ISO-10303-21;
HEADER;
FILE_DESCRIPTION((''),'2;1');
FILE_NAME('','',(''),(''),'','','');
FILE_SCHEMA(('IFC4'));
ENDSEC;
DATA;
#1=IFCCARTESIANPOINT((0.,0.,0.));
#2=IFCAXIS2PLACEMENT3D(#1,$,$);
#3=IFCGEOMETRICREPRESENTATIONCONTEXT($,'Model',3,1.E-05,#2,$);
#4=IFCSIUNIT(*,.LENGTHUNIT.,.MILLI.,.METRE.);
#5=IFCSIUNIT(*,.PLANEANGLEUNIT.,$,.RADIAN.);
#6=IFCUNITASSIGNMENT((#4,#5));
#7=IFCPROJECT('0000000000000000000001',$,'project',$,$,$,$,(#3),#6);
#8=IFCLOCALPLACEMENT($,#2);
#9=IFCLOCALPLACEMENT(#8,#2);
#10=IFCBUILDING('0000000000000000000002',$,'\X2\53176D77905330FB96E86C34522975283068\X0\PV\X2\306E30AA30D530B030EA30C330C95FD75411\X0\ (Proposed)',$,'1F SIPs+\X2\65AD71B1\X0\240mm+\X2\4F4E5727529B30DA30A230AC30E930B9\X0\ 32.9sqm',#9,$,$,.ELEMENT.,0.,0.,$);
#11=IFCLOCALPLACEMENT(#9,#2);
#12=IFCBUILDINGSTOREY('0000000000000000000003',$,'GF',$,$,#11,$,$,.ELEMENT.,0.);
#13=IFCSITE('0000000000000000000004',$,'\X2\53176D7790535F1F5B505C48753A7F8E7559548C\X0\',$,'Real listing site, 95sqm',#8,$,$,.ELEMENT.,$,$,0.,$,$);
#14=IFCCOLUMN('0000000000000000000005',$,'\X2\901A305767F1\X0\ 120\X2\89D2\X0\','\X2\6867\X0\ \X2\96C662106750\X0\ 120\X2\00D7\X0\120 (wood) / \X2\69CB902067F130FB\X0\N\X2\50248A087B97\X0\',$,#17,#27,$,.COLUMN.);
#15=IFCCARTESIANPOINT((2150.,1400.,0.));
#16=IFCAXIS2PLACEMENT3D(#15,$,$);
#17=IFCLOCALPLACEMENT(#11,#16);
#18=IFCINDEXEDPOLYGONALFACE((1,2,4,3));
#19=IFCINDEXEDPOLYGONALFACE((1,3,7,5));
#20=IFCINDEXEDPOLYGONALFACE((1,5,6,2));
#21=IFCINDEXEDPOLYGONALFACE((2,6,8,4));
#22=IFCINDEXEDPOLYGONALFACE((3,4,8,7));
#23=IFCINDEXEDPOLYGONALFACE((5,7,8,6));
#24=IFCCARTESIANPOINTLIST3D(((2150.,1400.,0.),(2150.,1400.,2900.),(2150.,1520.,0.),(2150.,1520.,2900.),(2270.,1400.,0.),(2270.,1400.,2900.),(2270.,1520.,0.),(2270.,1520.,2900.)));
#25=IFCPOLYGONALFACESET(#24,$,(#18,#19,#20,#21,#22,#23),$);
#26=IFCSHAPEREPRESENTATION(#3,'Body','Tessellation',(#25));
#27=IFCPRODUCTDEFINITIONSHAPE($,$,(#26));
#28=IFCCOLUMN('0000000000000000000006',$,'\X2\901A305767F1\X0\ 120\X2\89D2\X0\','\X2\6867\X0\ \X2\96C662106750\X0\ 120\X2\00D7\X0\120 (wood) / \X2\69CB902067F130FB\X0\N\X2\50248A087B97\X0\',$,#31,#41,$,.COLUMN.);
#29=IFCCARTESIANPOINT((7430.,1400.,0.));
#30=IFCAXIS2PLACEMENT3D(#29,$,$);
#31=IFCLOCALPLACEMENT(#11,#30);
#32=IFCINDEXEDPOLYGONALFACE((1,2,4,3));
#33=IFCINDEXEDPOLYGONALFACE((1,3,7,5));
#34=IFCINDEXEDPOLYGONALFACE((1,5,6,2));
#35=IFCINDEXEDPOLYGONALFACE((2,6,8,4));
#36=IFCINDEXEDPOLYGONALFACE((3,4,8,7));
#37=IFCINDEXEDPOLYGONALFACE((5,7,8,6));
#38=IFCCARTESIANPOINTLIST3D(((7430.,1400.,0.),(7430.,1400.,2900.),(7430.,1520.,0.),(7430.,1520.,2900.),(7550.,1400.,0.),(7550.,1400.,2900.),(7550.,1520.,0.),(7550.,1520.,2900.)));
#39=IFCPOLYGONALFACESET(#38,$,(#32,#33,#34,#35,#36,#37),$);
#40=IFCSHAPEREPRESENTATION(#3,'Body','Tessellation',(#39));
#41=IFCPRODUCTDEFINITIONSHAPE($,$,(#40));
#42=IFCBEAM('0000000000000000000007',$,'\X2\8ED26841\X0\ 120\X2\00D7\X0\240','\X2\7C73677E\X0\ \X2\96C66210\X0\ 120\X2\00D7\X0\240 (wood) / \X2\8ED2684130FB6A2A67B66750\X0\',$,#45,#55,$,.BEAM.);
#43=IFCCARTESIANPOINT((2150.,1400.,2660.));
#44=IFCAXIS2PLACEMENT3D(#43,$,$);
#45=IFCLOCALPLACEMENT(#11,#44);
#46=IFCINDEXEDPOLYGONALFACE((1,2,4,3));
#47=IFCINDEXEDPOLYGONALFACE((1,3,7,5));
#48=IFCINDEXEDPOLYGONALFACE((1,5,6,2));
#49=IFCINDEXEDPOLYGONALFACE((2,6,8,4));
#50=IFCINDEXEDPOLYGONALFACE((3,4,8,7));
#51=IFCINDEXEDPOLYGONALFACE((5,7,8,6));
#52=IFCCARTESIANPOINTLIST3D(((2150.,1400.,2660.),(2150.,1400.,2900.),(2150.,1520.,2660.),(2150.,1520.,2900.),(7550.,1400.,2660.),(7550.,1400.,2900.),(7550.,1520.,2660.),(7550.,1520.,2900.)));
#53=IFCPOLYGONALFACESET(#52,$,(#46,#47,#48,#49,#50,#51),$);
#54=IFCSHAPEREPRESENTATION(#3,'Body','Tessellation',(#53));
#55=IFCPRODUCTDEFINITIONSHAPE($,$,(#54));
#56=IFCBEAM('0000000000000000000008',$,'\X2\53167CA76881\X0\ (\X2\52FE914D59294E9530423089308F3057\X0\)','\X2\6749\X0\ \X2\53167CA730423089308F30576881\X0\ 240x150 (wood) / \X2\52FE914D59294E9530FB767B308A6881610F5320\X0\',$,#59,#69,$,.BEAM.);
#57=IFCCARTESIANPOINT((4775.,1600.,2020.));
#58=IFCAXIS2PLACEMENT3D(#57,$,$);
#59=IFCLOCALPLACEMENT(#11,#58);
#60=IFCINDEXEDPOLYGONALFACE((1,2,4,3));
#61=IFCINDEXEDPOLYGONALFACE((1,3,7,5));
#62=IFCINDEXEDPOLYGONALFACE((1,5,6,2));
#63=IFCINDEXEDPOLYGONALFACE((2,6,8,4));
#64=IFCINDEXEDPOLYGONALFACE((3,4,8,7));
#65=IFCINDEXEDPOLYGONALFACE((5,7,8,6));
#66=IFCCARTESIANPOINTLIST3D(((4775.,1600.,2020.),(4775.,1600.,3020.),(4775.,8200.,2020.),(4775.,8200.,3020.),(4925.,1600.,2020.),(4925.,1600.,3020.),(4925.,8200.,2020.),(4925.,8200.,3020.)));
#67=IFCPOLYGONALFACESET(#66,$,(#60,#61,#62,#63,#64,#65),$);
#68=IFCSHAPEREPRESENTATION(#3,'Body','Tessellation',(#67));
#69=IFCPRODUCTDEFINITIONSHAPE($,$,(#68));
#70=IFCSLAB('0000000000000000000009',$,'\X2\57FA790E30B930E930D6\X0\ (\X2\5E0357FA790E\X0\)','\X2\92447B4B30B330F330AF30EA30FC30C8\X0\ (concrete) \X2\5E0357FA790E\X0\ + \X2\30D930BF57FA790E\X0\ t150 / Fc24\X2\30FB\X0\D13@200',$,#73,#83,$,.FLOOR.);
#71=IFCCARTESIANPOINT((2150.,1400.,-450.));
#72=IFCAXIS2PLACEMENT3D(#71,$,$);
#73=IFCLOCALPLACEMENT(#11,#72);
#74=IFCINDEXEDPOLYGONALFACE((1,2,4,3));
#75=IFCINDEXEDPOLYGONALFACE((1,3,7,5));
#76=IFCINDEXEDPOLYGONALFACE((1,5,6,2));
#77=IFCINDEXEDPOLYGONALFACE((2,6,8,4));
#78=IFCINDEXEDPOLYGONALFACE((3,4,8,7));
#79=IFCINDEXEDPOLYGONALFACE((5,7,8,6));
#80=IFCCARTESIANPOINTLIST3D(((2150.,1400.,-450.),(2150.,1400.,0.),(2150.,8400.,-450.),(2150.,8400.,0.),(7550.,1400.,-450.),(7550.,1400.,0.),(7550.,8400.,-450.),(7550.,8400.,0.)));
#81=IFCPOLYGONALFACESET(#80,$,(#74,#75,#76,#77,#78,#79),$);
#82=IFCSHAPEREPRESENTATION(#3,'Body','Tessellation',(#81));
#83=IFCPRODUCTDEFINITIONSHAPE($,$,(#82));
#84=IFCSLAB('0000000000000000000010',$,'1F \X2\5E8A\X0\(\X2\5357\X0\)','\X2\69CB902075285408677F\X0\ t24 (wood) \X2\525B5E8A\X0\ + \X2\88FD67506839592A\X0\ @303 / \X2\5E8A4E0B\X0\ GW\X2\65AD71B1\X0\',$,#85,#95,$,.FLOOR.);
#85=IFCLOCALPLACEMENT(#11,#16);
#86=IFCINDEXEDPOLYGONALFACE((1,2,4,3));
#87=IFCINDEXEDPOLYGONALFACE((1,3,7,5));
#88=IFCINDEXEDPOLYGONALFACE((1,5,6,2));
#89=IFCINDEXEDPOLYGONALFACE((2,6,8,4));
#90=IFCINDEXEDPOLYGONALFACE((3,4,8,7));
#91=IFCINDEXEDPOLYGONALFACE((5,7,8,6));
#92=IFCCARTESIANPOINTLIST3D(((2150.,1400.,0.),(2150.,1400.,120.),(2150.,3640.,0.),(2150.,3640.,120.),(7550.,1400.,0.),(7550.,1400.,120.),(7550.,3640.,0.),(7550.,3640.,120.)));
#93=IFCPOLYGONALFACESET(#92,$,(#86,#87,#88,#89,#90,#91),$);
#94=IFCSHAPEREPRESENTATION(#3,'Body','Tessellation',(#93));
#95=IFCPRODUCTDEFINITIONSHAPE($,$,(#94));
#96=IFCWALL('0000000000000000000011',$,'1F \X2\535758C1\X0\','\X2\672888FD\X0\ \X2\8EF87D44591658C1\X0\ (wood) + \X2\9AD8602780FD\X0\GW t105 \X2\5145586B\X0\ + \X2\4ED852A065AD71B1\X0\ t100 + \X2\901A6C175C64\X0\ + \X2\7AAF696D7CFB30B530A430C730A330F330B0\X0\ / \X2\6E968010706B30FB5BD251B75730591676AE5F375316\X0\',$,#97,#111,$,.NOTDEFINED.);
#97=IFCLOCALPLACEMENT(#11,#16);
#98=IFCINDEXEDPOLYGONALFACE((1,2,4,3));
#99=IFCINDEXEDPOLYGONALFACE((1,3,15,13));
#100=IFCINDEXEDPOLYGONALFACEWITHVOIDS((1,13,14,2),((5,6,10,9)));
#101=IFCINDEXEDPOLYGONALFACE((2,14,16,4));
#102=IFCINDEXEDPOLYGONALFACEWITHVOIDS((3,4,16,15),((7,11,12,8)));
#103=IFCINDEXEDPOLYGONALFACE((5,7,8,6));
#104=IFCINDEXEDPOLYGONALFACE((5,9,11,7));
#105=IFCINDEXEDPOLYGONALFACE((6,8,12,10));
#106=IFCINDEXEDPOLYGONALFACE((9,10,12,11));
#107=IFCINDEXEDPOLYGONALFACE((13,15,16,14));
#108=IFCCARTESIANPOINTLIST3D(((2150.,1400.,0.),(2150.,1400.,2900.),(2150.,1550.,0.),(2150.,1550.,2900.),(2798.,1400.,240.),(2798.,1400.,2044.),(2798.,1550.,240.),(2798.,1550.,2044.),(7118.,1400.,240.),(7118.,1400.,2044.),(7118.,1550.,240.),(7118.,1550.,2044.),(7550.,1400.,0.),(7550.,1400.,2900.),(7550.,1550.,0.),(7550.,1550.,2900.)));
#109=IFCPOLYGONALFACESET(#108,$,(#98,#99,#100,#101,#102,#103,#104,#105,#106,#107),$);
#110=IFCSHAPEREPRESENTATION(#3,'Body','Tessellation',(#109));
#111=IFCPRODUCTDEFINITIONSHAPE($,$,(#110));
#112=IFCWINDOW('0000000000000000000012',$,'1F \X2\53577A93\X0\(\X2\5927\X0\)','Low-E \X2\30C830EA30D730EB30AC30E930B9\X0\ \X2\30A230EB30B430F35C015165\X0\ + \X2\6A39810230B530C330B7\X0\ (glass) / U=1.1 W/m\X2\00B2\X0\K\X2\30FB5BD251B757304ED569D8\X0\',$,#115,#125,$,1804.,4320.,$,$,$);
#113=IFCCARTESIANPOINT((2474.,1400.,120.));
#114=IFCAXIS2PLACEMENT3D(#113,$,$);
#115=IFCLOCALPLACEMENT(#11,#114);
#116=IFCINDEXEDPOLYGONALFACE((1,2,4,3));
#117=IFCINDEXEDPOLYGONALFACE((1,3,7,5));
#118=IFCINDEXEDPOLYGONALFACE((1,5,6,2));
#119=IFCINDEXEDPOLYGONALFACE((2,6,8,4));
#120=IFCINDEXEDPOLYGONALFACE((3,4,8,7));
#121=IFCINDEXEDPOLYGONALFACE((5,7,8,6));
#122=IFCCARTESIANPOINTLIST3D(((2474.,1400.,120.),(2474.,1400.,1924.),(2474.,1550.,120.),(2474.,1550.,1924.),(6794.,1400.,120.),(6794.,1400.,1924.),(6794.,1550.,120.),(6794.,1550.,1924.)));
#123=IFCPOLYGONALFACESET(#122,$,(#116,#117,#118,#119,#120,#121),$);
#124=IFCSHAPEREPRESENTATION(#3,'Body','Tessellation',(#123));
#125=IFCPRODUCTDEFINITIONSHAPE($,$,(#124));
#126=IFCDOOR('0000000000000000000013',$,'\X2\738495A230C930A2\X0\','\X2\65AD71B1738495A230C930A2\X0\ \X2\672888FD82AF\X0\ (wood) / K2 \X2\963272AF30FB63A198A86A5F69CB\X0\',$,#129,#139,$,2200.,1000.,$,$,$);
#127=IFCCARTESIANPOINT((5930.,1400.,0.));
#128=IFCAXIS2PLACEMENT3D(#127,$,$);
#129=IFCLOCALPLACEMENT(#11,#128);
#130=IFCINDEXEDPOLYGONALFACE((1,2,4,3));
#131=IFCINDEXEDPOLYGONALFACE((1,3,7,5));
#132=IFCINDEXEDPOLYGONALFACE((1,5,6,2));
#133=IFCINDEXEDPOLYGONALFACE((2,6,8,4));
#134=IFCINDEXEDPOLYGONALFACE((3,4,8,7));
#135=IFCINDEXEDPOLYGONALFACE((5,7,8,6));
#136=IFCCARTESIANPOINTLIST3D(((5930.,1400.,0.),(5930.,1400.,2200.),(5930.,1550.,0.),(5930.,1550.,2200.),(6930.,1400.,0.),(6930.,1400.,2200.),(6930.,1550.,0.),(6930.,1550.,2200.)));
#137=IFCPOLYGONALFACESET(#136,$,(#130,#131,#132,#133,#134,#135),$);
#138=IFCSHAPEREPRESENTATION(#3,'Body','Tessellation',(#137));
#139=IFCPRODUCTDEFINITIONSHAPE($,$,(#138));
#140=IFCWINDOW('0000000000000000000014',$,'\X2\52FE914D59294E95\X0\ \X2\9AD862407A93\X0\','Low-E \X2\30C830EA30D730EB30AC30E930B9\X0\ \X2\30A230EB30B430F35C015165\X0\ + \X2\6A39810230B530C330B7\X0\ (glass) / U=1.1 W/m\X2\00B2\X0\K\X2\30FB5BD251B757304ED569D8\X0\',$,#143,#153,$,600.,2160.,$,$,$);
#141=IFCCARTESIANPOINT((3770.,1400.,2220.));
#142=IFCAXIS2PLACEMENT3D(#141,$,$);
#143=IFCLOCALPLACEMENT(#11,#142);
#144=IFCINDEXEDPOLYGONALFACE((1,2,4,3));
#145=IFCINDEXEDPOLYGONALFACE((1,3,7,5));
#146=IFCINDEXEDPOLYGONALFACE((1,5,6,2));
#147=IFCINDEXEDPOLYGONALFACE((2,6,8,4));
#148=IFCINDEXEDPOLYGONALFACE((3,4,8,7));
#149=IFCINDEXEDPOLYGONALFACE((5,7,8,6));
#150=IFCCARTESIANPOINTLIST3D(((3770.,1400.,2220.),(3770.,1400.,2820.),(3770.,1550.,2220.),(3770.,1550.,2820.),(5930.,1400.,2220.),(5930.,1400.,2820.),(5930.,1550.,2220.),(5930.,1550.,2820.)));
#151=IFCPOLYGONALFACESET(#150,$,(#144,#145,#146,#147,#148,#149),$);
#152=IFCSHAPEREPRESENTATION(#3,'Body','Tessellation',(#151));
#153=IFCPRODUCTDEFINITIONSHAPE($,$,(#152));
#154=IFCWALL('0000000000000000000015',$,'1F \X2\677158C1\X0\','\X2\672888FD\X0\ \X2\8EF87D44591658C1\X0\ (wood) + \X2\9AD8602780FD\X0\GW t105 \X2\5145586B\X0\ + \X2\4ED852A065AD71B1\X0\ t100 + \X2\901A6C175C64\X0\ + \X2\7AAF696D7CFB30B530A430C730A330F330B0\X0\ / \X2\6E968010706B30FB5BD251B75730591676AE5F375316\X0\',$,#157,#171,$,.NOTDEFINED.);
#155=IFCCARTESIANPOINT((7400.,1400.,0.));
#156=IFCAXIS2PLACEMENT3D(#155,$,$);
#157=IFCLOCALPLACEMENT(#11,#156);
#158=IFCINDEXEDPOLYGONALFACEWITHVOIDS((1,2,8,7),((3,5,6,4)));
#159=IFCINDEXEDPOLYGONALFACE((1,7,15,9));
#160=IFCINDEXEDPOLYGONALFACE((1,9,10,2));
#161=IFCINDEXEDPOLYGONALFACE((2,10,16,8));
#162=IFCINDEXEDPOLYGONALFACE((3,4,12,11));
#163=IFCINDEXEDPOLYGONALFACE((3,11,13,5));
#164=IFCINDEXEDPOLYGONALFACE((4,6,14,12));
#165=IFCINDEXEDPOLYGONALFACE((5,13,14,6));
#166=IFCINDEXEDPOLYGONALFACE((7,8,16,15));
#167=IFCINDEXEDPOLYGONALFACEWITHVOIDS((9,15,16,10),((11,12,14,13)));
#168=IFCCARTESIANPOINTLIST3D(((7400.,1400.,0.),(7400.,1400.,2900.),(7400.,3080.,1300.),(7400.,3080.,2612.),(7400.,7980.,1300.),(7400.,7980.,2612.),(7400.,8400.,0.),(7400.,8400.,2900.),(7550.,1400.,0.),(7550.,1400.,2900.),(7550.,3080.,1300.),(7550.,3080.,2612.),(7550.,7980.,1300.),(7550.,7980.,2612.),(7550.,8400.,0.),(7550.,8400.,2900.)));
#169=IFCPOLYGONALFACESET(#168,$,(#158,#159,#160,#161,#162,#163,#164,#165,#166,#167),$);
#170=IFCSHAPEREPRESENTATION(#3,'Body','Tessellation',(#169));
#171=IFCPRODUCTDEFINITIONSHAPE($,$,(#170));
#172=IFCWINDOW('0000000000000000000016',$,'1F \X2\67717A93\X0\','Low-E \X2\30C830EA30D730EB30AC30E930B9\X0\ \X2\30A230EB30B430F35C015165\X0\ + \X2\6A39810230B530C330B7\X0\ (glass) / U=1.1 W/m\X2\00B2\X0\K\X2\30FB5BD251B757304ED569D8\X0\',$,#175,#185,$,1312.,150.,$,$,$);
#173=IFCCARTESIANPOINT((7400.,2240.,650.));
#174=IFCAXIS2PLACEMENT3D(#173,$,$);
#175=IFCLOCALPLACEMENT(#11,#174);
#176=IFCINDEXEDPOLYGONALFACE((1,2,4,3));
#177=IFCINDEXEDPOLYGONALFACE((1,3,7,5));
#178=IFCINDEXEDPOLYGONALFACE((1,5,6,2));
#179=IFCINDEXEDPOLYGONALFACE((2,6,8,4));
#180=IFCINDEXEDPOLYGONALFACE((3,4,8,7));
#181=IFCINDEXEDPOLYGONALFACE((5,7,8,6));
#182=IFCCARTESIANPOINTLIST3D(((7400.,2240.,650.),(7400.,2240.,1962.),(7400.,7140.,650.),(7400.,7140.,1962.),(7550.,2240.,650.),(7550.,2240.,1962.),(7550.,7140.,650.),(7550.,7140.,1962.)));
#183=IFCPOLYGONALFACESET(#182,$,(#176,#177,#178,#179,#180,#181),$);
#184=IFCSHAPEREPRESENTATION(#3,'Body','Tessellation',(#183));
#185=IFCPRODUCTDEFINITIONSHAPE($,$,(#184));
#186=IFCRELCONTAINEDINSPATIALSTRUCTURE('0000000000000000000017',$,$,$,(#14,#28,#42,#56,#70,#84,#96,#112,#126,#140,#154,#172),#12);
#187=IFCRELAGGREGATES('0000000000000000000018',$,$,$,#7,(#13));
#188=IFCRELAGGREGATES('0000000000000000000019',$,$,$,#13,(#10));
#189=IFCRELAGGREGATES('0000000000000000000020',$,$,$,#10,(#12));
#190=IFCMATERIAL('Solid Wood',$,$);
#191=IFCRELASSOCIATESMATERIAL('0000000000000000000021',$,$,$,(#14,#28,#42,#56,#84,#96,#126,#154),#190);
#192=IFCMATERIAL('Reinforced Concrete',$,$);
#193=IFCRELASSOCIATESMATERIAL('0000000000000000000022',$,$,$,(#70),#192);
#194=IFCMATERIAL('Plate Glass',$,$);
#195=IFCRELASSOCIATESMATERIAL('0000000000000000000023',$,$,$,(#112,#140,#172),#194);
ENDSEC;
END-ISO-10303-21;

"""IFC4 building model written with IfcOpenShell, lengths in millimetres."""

from ifc_helpers import new_model, si_unit, frame, frame_2d, origin, place, context, project, spatial, rectangle, extrude, material, element, fill, save


model = new_model("IFC4")

# Units and contexts
model_context = context("Model", 3, precision=1e-05, world=origin())
ifc_project = project(units=[si_unit("LENGTHUNIT", "METRE", prefix="MILLI"), si_unit("PLANEANGLEUNIT", "RADIAN")], contexts=[model_context])

# Site, building, storey
site_placement = place(None, origin())
site = spatial("IfcSite", under=ifc_project, at=site_placement, Name="北海道弟子屈町美留和", ObjectType="Real listing site, 95sqm", CompositionType="ELEMENT", RefElevation=0.0)
building_placement = place(site_placement, origin())
building = spatial("IfcBuilding", under=site, at=building_placement, Name="北海道・雨水利用とPVのオフグリッド志向 (Proposed)", ObjectType="1F SIPs+断熱240mm+低圧力ペアガラス 32.9sqm", CompositionType="ELEMENT", ElevationOfRefHeight=0.0, ElevationOfTerrain=0.0)
storey_placement = place(building_placement, origin())
storey = spatial("IfcBuildingStorey", under=building, at=storey_placement, Name="GF", CompositionType="ELEMENT", Elevation=0.0)

# Columns
ifc_material_1 = material(Name="Solid Wood")
column_1_placement = place(storey_placement, frame((2150.0, 1400.0, 0.0)))
element("IfcColumn", 1, at=column_1_placement, inside=storey, material=ifc_material_1, Name="通し柱 120角", Description="桧 集成材 120×120 (wood) / 構造柱・N値計算", PredefinedType="COLUMN", context=model_context, shape_type="SweptSolid", body=[
    extrude(rectangle(XDim=120.0, YDim=120.0, at=frame_2d((60.0, 60.0))), frame((2150.0, 1400.0, 0.0)), (0.0, 0.0, 1.0), 2900.0),
])
column_2_placement = place(storey_placement, frame((7430.0, 1400.0, 0.0)))
element("IfcColumn", 2, at=column_2_placement, inside=storey, material=ifc_material_1, Name="通し柱 120角", Description="桧 集成材 120×120 (wood) / 構造柱・N値計算", PredefinedType="COLUMN", context=model_context, shape_type="SweptSolid", body=[
    extrude(rectangle(XDim=120.0, YDim=120.0, at=frame_2d((60.0, 60.0))), frame((7430.0, 1400.0, 0.0)), (0.0, 0.0, 1.0), 2900.0),
])

# Beams
beam_1_placement = place(storey_placement, frame((2150.0, 1400.0, 2660.0)))
element("IfcBeam", 3, at=beam_1_placement, inside=storey, material=ifc_material_1, Name="軒桁 120×240", Description="米松 集成 120×240 (wood) / 軒桁・横架材", PredefinedType="BEAM", context=model_context, shape_type="SweptSolid", body=[
    extrude(rectangle(XDim=5400.0, YDim=120.0, at=frame_2d((2700.0, 60.0))), frame((2150.0, 1400.0, 2660.0)), (0.0, 0.0, 1.0), 240.0),
])
beam_2_placement = place(storey_placement, frame((4775.0, 1600.0, 2020.0)))
element("IfcBeam", 4, at=beam_2_placement, inside=storey, material=ifc_material_1, Name="化粧梁 (勾配天井あらわし)", Description="杉 化粧あらわし梁 240x150 (wood) / 勾配天井・登り梁意匠", PredefinedType="BEAM", context=model_context, shape_type="SweptSolid", body=[
    extrude(rectangle(XDim=150.0, YDim=6600.0, at=frame_2d((75.0, 3300.0))), frame((4775.0, 1600.0, 2020.0)), (0.0, 0.0, 1.0), 1000.0),
])

# Slabs
ifc_material_2 = material(Name="Reinforced Concrete")
slab_1_placement = place(storey_placement, frame((2150.0, 1400.0, -450.0)))
element("IfcSlab", 5, at=slab_1_placement, inside=storey, material=ifc_material_2, Name="基礎スラブ (布基礎)", Description="鉄筋コンクリート (concrete) 布基礎 + ベタ基礎 t150 / Fc24・D13@200", PredefinedType="FLOOR", context=model_context, shape_type="SweptSolid", body=[
    extrude(rectangle(XDim=5400.0, YDim=7000.0, at=frame_2d((2700.0, 3500.0))), frame((2150.0, 1400.0, -450.0)), (0.0, 0.0, 1.0), 450.0),
])
slab_2_placement = place(storey_placement, frame((2150.0, 1400.0, 0.0)))
element("IfcSlab", 6, at=slab_2_placement, inside=storey, material=ifc_material_1, Name="1F 床(南)", Description="構造用合板 t24 (wood) 剛床 + 製材根太 @303 / 床下 GW断熱", PredefinedType="FLOOR", context=model_context, shape_type="SweptSolid", body=[
    extrude(rectangle(XDim=5400.0, YDim=2240.0, at=frame_2d((2700.0, 1120.0))), frame((2150.0, 1400.0, 0.0)), (0.0, 0.0, 1.0), 120.0),
])

# Wall, openings, windows, door
wall_1_placement = place(storey_placement, frame((2150.0, 1400.0, 0.0)))
wall_1 = element("IfcWall", 7, at=wall_1_placement, inside=storey, material=ifc_material_1, Name="1F 南壁", Description="木製 軸組外壁 (wood) + 高性能GW t105 充填 + 付加断熱 t100 + 通気層 + 窯業系サイディング / 準耐火・寒冷地外皮強化", PredefinedType="NOTDEFINED", context=model_context, shape_type="SweptSolid", body=[
    extrude(rectangle(XDim=5400.0, YDim=150.0, at=frame_2d((2700.0, 75.0))), frame((2150.0, 1400.0, 0.0)), (0.0, 0.0, 1.0), 2900.0),
])
opening_1_placement = place(storey_placement, frame((2474.0, 1400.0, 120.0)))
opening_1 = element("IfcOpeningElement", 8, at=opening_1_placement, cuts=wall_1, PredefinedType="NOTDEFINED", context=model_context, shape_type="SweptSolid", body=[
    extrude(rectangle(XDim=4320.0, YDim=150.0, at=frame_2d((2160.0, 75.0))), frame((2474.0, 1400.0, 120.0)), (0.0, 0.0, 1.0), 1804.0),
])
opening_2_placement = place(storey_placement, frame((5930.0, 1400.0, 0.0)))
opening_2 = element("IfcOpeningElement", 9, at=opening_2_placement, cuts=wall_1, PredefinedType="NOTDEFINED", context=model_context, shape_type="SweptSolid", body=[
    extrude(rectangle(XDim=1000.0, YDim=150.0, at=frame_2d((500.0, 75.0))), frame((5930.0, 1400.0, 0.0)), (0.0, 0.0, 1.0), 2200.0),
])
opening_3_placement = place(storey_placement, frame((3770.0, 1400.0, 2220.0)))
opening_3 = element("IfcOpeningElement", 10, at=opening_3_placement, cuts=wall_1, PredefinedType="NOTDEFINED", context=model_context, shape_type="SweptSolid", body=[
    extrude(rectangle(XDim=2160.0, YDim=150.0, at=frame_2d((1080.0, 75.0))), frame((3770.0, 1400.0, 2220.0)), (0.0, 0.0, 1.0), 600.0),
])
ifc_material_3 = material(Name="Plate Glass")
window_1_placement = place(storey_placement, frame((2474.0, 1400.0, 120.0)))
window_1 = element("IfcWindow", 11, at=window_1_placement, inside=storey, material=ifc_material_3, Name="1F 南窓(大)", Description="Low-E トリプルガラス アルゴン封入 + 樹脂サッシ (glass) / U=1.1 W/m²K・寒冷地仕様", OverallHeight=1804.0, OverallWidth=4320.0, context=model_context, shape_type="SweptSolid", body=[
    extrude(rectangle(XDim=4320.0, YDim=150.0, at=frame_2d((2160.0, 75.0))), frame((2474.0, 1400.0, 120.0)), (0.0, 0.0, 1.0), 1804.0),
])
fill(opening_1, window_1)
door_placement = place(storey_placement, frame((5930.0, 1400.0, 0.0)))
door = element("IfcDoor", 12, at=door_placement, inside=storey, material=ifc_material_1, Name="玄関ドア", Description="断熱玄関ドア 木製芯 (wood) / K2 防犯・採風機構", OverallHeight=2200.0, OverallWidth=1000.0, context=model_context, shape_type="SweptSolid", body=[
    extrude(rectangle(XDim=1000.0, YDim=150.0, at=frame_2d((500.0, 75.0))), frame((5930.0, 1400.0, 0.0)), (0.0, 0.0, 1.0), 2200.0),
])
fill(opening_2, door)
window_2_placement = place(storey_placement, frame((3770.0, 1400.0, 2220.0)))
window_2 = element("IfcWindow", 13, at=window_2_placement, inside=storey, material=ifc_material_3, Name="勾配天井 高所窓", Description="Low-E トリプルガラス アルゴン封入 + 樹脂サッシ (glass) / U=1.1 W/m²K・寒冷地仕様", OverallHeight=600.0, OverallWidth=2160.0, context=model_context, shape_type="SweptSolid", body=[
    extrude(rectangle(XDim=2160.0, YDim=150.0, at=frame_2d((1080.0, 75.0))), frame((3770.0, 1400.0, 2220.0)), (0.0, 0.0, 1.0), 600.0),
])
fill(opening_3, window_2)

# Wall, opening, window
wall_2_placement = place(storey_placement, frame((7400.0, 1400.0, 0.0)))
wall_2 = element("IfcWall", 14, at=wall_2_placement, inside=storey, material=ifc_material_1, Name="1F 東壁", Description="木製 軸組外壁 (wood) + 高性能GW t105 充填 + 付加断熱 t100 + 通気層 + 窯業系サイディング / 準耐火・寒冷地外皮強化", PredefinedType="NOTDEFINED", context=model_context, shape_type="SweptSolid", body=[
    extrude(rectangle(XDim=150.0, YDim=7000.0, at=frame_2d((75.0, 3500.0))), frame((7400.0, 1400.0, 0.0)), (0.0, 0.0, 1.0), 2900.0),
])
opening_4_placement = place(storey_placement, frame((7400.0, 2240.0, 650.0)))
opening_4 = element("IfcOpeningElement", 15, at=opening_4_placement, cuts=wall_2, PredefinedType="NOTDEFINED", context=model_context, shape_type="SweptSolid", body=[
    extrude(rectangle(XDim=150.0, YDim=4900.0, at=frame_2d((75.0, 2450.0))), frame((7400.0, 2240.0, 650.0)), (0.0, 0.0, 1.0), 1312.0),
])
window_3_placement = place(storey_placement, frame((7400.0, 2240.0, 650.0)))
window_3 = element("IfcWindow", 16, at=window_3_placement, inside=storey, material=ifc_material_3, Name="1F 東窓", Description="Low-E トリプルガラス アルゴン封入 + 樹脂サッシ (glass) / U=1.1 W/m²K・寒冷地仕様", OverallHeight=1312.0, OverallWidth=150.0, context=model_context, shape_type="SweptSolid", body=[
    extrude(rectangle(XDim=150.0, YDim=4900.0, at=frame_2d((75.0, 2450.0))), frame((7400.0, 2240.0, 650.0)), (0.0, 0.0, 1.0), 1312.0),
])
fill(opening_4, window_3)

save(model, "model.ifc")
